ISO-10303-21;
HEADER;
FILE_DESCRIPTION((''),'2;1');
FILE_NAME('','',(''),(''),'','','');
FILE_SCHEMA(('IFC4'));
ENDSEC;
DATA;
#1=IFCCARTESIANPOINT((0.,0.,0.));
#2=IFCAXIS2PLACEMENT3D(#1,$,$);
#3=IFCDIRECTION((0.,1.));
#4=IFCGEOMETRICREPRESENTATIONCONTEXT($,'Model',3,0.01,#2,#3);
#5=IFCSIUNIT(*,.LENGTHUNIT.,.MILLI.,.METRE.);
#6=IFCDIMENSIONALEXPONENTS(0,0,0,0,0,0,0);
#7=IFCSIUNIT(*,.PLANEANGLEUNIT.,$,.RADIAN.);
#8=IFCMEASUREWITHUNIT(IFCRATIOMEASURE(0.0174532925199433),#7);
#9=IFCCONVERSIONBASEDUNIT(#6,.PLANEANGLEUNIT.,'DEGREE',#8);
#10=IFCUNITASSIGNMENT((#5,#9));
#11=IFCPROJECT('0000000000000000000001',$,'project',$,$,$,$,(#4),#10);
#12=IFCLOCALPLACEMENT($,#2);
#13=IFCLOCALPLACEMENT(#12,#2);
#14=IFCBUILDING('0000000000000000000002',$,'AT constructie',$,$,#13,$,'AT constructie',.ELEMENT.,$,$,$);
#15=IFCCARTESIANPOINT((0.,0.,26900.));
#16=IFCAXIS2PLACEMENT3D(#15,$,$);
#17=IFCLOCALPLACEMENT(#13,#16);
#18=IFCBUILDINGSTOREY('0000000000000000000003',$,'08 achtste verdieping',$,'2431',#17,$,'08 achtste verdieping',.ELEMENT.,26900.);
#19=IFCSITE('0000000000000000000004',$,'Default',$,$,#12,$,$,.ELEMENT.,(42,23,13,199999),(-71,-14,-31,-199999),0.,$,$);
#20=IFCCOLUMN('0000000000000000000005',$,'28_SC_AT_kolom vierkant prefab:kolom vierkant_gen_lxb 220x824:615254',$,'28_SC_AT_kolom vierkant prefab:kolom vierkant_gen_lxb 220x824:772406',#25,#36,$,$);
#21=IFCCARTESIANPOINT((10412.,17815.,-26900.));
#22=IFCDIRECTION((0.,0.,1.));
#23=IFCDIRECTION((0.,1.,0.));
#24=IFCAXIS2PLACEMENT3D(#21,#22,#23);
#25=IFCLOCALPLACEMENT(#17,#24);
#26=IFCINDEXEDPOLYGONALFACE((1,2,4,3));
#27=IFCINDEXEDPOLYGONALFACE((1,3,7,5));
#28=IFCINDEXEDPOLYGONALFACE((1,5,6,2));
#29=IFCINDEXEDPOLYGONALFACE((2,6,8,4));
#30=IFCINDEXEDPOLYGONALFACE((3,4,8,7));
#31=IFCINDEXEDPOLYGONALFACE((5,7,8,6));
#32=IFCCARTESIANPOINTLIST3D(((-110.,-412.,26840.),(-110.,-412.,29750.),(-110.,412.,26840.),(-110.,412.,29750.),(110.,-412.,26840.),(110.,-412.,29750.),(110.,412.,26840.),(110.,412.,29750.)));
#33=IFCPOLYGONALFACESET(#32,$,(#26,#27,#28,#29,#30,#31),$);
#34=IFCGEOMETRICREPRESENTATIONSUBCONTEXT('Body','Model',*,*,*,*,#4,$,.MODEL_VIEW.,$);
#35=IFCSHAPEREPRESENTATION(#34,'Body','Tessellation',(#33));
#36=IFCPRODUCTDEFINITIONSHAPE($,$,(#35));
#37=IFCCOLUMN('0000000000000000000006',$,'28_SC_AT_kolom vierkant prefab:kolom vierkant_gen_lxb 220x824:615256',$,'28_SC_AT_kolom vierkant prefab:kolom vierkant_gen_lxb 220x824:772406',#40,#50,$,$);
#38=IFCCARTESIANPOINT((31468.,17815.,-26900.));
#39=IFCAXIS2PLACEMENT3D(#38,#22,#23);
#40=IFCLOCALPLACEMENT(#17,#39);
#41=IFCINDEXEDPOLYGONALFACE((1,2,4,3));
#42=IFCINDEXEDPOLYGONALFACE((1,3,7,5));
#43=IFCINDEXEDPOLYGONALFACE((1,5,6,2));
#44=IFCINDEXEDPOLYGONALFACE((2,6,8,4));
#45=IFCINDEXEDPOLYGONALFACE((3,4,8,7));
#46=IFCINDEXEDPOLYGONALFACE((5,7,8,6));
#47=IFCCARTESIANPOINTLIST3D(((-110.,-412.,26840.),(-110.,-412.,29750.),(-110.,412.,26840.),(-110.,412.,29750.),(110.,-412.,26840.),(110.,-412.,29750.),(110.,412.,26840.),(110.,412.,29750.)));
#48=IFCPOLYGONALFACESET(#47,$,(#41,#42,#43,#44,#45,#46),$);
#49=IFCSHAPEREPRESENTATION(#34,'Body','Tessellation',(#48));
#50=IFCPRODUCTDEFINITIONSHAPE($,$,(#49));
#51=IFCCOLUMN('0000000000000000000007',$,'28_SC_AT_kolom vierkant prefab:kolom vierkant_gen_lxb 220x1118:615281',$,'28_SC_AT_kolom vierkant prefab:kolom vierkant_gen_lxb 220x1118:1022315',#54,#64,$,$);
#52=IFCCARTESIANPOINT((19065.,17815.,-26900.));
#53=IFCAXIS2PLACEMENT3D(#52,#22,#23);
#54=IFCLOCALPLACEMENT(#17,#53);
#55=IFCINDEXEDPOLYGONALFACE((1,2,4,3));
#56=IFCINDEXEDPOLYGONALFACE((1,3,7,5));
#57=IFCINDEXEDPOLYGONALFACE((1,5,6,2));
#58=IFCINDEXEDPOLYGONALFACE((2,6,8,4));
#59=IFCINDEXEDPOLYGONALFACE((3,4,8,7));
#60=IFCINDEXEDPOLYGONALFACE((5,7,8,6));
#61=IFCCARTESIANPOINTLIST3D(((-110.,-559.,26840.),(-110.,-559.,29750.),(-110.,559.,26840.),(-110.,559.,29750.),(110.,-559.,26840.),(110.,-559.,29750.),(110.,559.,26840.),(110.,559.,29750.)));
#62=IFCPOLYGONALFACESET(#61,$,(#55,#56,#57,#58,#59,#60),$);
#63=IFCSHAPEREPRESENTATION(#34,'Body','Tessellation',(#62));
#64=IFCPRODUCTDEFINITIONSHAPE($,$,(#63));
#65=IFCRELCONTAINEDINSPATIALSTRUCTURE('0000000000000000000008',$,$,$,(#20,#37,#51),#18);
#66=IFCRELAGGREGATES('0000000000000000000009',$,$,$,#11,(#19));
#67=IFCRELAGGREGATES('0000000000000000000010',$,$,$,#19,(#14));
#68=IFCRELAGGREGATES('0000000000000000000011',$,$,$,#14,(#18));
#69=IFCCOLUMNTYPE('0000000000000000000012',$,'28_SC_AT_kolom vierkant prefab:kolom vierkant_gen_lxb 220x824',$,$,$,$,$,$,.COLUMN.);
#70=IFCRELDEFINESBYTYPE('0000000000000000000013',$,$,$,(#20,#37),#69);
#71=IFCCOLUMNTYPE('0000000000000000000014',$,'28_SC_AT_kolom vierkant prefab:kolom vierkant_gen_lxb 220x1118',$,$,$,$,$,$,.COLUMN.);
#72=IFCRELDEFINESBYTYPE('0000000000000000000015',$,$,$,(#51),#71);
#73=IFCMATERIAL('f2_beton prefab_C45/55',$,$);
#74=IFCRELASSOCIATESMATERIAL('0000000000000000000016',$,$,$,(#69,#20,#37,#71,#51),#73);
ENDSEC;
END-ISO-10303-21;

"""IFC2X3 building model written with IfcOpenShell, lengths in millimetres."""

from ifc_helpers import new_model, entity, si_unit, converted_unit, direction, frame, origin, origin_2d_with_axis, place, context, subcontext, project, spatial, rectangle, extrude, source, transform, mapped, material, type_object, type_shapes, element, save


model = new_model("IFC2X3")

# Units and contexts
model_context = context("Model", 3, precision=0.01, world=origin(), true_north=direction((0.0, 1.0)))
body_context = subcontext(model_context, "Body", "Model", "MODEL_VIEW")
ifc_project = project(units=[si_unit("LENGTHUNIT", "METRE", prefix="MILLI"), converted_unit("PLANEANGLEUNIT", "DEGREE", entity("IfcRatioMeasure", 0.0174532925199433), si_unit("PLANEANGLEUNIT", "RADIAN"), dimensions=[0, 0, 0, 0, 0, 0, 0])], contexts=[model_context])

# Site, building, storey
site_placement = place(None, origin())
site = spatial("IfcSite", under=ifc_project, at=site_placement, Name="Default", CompositionType="ELEMENT", RefLatitude=(42, 23, 13, 199999), RefLongitude=(-71, -14, -31, -199999), RefElevation=0.0)
building_placement = place(site_placement, origin())
building = spatial("IfcBuilding", under=site, at=building_placement, Name="AT constructie", LongName="AT constructie", CompositionType="ELEMENT")
storey_placement = place(building_placement, frame((0.0, 0.0, 26900.0)))
storey = spatial("IfcBuildingStorey", under=building, at=storey_placement, Name="08 achtste verdieping", ObjectType="2431", LongName="08 achtste verdieping", CompositionType="ELEMENT", Elevation=26900.0)

# Columns
ifc_material_1 = material(Name="f2_beton prefab_C45/55")
column_type_1 = type_object("IfcColumnType", Name="28_SC_AT_kolom vierkant prefab:kolom vierkant_gen_lxb 220x824", PredefinedType="COLUMN", material=ifc_material_1)
shared_shape_1 = source(origin(), body_context, "Body", "SweptSolid", [
    extrude(rectangle(XDim=220.0, YDim=824.0, at=origin_2d_with_axis()), frame((0.0, 0.0, 26840.0), z_axis=(0.0, 0.0, 1.0), x_axis=(-1.0, 0.0, 0.0)), (0.0, 0.0, 1.0), 2910.0),
])
type_shapes(column_type_1, [shared_shape_1])
for number, where, z_axis, x_axis, name in (
    (1, (10412.0, 17815.0, -26900.0), (0.0, 0.0, 1.0), (0.0, 1.0, 0.0), "28_SC_AT_kolom vierkant prefab:kolom vierkant_gen_lxb 220x824:615254"),
    (2, (31468.0, 17815.0, -26900.0), (0.0, 0.0, 1.0), (0.0, 1.0, 0.0), "28_SC_AT_kolom vierkant prefab:kolom vierkant_gen_lxb 220x824:615256"),
):
    element("IfcColumn", number, at=place(storey_placement, frame(where, z_axis=z_axis, x_axis=x_axis)), inside=storey, type_object=column_type_1, material=ifc_material_1, Name=name, ObjectType="28_SC_AT_kolom vierkant prefab:kolom vierkant_gen_lxb 220x824:772406", context=body_context, shape_type="MappedRepresentation", body=[
        mapped(shared_shape_1, transform((0.0, 0.0, 0.0), scale=1.0)),
    ])
column_type_2 = type_object("IfcColumnType", Name="28_SC_AT_kolom vierkant prefab:kolom vierkant_gen_lxb 220x1118", PredefinedType="COLUMN", material=ifc_material_1)
shared_shape_2 = source(origin(), body_context, "Body", "SweptSolid", [
    extrude(rectangle(XDim=220.0, YDim=1118.0, at=origin_2d_with_axis()), frame((0.0, 0.0, 26840.0), z_axis=(0.0, 0.0, 1.0), x_axis=(-1.0, 0.0, 0.0)), (0.0, 0.0, 1.0), 2910.0),
])
type_shapes(column_type_2, [shared_shape_2])
column_placement = place(storey_placement, frame((19065.0, 17815.0, -26900.0), z_axis=(0.0, 0.0, 1.0), x_axis=(0.0, 1.0, 0.0)))
element("IfcColumn", 3, at=column_placement, inside=storey, type_object=column_type_2, material=ifc_material_1, Name="28_SC_AT_kolom vierkant prefab:kolom vierkant_gen_lxb 220x1118:615281", ObjectType="28_SC_AT_kolom vierkant prefab:kolom vierkant_gen_lxb 220x1118:1022315", context=body_context, shape_type="MappedRepresentation", body=[
    mapped(shared_shape_2, transform((0.0, 0.0, 0.0), scale=1.0)),
])

save(model, "model.ifc")
